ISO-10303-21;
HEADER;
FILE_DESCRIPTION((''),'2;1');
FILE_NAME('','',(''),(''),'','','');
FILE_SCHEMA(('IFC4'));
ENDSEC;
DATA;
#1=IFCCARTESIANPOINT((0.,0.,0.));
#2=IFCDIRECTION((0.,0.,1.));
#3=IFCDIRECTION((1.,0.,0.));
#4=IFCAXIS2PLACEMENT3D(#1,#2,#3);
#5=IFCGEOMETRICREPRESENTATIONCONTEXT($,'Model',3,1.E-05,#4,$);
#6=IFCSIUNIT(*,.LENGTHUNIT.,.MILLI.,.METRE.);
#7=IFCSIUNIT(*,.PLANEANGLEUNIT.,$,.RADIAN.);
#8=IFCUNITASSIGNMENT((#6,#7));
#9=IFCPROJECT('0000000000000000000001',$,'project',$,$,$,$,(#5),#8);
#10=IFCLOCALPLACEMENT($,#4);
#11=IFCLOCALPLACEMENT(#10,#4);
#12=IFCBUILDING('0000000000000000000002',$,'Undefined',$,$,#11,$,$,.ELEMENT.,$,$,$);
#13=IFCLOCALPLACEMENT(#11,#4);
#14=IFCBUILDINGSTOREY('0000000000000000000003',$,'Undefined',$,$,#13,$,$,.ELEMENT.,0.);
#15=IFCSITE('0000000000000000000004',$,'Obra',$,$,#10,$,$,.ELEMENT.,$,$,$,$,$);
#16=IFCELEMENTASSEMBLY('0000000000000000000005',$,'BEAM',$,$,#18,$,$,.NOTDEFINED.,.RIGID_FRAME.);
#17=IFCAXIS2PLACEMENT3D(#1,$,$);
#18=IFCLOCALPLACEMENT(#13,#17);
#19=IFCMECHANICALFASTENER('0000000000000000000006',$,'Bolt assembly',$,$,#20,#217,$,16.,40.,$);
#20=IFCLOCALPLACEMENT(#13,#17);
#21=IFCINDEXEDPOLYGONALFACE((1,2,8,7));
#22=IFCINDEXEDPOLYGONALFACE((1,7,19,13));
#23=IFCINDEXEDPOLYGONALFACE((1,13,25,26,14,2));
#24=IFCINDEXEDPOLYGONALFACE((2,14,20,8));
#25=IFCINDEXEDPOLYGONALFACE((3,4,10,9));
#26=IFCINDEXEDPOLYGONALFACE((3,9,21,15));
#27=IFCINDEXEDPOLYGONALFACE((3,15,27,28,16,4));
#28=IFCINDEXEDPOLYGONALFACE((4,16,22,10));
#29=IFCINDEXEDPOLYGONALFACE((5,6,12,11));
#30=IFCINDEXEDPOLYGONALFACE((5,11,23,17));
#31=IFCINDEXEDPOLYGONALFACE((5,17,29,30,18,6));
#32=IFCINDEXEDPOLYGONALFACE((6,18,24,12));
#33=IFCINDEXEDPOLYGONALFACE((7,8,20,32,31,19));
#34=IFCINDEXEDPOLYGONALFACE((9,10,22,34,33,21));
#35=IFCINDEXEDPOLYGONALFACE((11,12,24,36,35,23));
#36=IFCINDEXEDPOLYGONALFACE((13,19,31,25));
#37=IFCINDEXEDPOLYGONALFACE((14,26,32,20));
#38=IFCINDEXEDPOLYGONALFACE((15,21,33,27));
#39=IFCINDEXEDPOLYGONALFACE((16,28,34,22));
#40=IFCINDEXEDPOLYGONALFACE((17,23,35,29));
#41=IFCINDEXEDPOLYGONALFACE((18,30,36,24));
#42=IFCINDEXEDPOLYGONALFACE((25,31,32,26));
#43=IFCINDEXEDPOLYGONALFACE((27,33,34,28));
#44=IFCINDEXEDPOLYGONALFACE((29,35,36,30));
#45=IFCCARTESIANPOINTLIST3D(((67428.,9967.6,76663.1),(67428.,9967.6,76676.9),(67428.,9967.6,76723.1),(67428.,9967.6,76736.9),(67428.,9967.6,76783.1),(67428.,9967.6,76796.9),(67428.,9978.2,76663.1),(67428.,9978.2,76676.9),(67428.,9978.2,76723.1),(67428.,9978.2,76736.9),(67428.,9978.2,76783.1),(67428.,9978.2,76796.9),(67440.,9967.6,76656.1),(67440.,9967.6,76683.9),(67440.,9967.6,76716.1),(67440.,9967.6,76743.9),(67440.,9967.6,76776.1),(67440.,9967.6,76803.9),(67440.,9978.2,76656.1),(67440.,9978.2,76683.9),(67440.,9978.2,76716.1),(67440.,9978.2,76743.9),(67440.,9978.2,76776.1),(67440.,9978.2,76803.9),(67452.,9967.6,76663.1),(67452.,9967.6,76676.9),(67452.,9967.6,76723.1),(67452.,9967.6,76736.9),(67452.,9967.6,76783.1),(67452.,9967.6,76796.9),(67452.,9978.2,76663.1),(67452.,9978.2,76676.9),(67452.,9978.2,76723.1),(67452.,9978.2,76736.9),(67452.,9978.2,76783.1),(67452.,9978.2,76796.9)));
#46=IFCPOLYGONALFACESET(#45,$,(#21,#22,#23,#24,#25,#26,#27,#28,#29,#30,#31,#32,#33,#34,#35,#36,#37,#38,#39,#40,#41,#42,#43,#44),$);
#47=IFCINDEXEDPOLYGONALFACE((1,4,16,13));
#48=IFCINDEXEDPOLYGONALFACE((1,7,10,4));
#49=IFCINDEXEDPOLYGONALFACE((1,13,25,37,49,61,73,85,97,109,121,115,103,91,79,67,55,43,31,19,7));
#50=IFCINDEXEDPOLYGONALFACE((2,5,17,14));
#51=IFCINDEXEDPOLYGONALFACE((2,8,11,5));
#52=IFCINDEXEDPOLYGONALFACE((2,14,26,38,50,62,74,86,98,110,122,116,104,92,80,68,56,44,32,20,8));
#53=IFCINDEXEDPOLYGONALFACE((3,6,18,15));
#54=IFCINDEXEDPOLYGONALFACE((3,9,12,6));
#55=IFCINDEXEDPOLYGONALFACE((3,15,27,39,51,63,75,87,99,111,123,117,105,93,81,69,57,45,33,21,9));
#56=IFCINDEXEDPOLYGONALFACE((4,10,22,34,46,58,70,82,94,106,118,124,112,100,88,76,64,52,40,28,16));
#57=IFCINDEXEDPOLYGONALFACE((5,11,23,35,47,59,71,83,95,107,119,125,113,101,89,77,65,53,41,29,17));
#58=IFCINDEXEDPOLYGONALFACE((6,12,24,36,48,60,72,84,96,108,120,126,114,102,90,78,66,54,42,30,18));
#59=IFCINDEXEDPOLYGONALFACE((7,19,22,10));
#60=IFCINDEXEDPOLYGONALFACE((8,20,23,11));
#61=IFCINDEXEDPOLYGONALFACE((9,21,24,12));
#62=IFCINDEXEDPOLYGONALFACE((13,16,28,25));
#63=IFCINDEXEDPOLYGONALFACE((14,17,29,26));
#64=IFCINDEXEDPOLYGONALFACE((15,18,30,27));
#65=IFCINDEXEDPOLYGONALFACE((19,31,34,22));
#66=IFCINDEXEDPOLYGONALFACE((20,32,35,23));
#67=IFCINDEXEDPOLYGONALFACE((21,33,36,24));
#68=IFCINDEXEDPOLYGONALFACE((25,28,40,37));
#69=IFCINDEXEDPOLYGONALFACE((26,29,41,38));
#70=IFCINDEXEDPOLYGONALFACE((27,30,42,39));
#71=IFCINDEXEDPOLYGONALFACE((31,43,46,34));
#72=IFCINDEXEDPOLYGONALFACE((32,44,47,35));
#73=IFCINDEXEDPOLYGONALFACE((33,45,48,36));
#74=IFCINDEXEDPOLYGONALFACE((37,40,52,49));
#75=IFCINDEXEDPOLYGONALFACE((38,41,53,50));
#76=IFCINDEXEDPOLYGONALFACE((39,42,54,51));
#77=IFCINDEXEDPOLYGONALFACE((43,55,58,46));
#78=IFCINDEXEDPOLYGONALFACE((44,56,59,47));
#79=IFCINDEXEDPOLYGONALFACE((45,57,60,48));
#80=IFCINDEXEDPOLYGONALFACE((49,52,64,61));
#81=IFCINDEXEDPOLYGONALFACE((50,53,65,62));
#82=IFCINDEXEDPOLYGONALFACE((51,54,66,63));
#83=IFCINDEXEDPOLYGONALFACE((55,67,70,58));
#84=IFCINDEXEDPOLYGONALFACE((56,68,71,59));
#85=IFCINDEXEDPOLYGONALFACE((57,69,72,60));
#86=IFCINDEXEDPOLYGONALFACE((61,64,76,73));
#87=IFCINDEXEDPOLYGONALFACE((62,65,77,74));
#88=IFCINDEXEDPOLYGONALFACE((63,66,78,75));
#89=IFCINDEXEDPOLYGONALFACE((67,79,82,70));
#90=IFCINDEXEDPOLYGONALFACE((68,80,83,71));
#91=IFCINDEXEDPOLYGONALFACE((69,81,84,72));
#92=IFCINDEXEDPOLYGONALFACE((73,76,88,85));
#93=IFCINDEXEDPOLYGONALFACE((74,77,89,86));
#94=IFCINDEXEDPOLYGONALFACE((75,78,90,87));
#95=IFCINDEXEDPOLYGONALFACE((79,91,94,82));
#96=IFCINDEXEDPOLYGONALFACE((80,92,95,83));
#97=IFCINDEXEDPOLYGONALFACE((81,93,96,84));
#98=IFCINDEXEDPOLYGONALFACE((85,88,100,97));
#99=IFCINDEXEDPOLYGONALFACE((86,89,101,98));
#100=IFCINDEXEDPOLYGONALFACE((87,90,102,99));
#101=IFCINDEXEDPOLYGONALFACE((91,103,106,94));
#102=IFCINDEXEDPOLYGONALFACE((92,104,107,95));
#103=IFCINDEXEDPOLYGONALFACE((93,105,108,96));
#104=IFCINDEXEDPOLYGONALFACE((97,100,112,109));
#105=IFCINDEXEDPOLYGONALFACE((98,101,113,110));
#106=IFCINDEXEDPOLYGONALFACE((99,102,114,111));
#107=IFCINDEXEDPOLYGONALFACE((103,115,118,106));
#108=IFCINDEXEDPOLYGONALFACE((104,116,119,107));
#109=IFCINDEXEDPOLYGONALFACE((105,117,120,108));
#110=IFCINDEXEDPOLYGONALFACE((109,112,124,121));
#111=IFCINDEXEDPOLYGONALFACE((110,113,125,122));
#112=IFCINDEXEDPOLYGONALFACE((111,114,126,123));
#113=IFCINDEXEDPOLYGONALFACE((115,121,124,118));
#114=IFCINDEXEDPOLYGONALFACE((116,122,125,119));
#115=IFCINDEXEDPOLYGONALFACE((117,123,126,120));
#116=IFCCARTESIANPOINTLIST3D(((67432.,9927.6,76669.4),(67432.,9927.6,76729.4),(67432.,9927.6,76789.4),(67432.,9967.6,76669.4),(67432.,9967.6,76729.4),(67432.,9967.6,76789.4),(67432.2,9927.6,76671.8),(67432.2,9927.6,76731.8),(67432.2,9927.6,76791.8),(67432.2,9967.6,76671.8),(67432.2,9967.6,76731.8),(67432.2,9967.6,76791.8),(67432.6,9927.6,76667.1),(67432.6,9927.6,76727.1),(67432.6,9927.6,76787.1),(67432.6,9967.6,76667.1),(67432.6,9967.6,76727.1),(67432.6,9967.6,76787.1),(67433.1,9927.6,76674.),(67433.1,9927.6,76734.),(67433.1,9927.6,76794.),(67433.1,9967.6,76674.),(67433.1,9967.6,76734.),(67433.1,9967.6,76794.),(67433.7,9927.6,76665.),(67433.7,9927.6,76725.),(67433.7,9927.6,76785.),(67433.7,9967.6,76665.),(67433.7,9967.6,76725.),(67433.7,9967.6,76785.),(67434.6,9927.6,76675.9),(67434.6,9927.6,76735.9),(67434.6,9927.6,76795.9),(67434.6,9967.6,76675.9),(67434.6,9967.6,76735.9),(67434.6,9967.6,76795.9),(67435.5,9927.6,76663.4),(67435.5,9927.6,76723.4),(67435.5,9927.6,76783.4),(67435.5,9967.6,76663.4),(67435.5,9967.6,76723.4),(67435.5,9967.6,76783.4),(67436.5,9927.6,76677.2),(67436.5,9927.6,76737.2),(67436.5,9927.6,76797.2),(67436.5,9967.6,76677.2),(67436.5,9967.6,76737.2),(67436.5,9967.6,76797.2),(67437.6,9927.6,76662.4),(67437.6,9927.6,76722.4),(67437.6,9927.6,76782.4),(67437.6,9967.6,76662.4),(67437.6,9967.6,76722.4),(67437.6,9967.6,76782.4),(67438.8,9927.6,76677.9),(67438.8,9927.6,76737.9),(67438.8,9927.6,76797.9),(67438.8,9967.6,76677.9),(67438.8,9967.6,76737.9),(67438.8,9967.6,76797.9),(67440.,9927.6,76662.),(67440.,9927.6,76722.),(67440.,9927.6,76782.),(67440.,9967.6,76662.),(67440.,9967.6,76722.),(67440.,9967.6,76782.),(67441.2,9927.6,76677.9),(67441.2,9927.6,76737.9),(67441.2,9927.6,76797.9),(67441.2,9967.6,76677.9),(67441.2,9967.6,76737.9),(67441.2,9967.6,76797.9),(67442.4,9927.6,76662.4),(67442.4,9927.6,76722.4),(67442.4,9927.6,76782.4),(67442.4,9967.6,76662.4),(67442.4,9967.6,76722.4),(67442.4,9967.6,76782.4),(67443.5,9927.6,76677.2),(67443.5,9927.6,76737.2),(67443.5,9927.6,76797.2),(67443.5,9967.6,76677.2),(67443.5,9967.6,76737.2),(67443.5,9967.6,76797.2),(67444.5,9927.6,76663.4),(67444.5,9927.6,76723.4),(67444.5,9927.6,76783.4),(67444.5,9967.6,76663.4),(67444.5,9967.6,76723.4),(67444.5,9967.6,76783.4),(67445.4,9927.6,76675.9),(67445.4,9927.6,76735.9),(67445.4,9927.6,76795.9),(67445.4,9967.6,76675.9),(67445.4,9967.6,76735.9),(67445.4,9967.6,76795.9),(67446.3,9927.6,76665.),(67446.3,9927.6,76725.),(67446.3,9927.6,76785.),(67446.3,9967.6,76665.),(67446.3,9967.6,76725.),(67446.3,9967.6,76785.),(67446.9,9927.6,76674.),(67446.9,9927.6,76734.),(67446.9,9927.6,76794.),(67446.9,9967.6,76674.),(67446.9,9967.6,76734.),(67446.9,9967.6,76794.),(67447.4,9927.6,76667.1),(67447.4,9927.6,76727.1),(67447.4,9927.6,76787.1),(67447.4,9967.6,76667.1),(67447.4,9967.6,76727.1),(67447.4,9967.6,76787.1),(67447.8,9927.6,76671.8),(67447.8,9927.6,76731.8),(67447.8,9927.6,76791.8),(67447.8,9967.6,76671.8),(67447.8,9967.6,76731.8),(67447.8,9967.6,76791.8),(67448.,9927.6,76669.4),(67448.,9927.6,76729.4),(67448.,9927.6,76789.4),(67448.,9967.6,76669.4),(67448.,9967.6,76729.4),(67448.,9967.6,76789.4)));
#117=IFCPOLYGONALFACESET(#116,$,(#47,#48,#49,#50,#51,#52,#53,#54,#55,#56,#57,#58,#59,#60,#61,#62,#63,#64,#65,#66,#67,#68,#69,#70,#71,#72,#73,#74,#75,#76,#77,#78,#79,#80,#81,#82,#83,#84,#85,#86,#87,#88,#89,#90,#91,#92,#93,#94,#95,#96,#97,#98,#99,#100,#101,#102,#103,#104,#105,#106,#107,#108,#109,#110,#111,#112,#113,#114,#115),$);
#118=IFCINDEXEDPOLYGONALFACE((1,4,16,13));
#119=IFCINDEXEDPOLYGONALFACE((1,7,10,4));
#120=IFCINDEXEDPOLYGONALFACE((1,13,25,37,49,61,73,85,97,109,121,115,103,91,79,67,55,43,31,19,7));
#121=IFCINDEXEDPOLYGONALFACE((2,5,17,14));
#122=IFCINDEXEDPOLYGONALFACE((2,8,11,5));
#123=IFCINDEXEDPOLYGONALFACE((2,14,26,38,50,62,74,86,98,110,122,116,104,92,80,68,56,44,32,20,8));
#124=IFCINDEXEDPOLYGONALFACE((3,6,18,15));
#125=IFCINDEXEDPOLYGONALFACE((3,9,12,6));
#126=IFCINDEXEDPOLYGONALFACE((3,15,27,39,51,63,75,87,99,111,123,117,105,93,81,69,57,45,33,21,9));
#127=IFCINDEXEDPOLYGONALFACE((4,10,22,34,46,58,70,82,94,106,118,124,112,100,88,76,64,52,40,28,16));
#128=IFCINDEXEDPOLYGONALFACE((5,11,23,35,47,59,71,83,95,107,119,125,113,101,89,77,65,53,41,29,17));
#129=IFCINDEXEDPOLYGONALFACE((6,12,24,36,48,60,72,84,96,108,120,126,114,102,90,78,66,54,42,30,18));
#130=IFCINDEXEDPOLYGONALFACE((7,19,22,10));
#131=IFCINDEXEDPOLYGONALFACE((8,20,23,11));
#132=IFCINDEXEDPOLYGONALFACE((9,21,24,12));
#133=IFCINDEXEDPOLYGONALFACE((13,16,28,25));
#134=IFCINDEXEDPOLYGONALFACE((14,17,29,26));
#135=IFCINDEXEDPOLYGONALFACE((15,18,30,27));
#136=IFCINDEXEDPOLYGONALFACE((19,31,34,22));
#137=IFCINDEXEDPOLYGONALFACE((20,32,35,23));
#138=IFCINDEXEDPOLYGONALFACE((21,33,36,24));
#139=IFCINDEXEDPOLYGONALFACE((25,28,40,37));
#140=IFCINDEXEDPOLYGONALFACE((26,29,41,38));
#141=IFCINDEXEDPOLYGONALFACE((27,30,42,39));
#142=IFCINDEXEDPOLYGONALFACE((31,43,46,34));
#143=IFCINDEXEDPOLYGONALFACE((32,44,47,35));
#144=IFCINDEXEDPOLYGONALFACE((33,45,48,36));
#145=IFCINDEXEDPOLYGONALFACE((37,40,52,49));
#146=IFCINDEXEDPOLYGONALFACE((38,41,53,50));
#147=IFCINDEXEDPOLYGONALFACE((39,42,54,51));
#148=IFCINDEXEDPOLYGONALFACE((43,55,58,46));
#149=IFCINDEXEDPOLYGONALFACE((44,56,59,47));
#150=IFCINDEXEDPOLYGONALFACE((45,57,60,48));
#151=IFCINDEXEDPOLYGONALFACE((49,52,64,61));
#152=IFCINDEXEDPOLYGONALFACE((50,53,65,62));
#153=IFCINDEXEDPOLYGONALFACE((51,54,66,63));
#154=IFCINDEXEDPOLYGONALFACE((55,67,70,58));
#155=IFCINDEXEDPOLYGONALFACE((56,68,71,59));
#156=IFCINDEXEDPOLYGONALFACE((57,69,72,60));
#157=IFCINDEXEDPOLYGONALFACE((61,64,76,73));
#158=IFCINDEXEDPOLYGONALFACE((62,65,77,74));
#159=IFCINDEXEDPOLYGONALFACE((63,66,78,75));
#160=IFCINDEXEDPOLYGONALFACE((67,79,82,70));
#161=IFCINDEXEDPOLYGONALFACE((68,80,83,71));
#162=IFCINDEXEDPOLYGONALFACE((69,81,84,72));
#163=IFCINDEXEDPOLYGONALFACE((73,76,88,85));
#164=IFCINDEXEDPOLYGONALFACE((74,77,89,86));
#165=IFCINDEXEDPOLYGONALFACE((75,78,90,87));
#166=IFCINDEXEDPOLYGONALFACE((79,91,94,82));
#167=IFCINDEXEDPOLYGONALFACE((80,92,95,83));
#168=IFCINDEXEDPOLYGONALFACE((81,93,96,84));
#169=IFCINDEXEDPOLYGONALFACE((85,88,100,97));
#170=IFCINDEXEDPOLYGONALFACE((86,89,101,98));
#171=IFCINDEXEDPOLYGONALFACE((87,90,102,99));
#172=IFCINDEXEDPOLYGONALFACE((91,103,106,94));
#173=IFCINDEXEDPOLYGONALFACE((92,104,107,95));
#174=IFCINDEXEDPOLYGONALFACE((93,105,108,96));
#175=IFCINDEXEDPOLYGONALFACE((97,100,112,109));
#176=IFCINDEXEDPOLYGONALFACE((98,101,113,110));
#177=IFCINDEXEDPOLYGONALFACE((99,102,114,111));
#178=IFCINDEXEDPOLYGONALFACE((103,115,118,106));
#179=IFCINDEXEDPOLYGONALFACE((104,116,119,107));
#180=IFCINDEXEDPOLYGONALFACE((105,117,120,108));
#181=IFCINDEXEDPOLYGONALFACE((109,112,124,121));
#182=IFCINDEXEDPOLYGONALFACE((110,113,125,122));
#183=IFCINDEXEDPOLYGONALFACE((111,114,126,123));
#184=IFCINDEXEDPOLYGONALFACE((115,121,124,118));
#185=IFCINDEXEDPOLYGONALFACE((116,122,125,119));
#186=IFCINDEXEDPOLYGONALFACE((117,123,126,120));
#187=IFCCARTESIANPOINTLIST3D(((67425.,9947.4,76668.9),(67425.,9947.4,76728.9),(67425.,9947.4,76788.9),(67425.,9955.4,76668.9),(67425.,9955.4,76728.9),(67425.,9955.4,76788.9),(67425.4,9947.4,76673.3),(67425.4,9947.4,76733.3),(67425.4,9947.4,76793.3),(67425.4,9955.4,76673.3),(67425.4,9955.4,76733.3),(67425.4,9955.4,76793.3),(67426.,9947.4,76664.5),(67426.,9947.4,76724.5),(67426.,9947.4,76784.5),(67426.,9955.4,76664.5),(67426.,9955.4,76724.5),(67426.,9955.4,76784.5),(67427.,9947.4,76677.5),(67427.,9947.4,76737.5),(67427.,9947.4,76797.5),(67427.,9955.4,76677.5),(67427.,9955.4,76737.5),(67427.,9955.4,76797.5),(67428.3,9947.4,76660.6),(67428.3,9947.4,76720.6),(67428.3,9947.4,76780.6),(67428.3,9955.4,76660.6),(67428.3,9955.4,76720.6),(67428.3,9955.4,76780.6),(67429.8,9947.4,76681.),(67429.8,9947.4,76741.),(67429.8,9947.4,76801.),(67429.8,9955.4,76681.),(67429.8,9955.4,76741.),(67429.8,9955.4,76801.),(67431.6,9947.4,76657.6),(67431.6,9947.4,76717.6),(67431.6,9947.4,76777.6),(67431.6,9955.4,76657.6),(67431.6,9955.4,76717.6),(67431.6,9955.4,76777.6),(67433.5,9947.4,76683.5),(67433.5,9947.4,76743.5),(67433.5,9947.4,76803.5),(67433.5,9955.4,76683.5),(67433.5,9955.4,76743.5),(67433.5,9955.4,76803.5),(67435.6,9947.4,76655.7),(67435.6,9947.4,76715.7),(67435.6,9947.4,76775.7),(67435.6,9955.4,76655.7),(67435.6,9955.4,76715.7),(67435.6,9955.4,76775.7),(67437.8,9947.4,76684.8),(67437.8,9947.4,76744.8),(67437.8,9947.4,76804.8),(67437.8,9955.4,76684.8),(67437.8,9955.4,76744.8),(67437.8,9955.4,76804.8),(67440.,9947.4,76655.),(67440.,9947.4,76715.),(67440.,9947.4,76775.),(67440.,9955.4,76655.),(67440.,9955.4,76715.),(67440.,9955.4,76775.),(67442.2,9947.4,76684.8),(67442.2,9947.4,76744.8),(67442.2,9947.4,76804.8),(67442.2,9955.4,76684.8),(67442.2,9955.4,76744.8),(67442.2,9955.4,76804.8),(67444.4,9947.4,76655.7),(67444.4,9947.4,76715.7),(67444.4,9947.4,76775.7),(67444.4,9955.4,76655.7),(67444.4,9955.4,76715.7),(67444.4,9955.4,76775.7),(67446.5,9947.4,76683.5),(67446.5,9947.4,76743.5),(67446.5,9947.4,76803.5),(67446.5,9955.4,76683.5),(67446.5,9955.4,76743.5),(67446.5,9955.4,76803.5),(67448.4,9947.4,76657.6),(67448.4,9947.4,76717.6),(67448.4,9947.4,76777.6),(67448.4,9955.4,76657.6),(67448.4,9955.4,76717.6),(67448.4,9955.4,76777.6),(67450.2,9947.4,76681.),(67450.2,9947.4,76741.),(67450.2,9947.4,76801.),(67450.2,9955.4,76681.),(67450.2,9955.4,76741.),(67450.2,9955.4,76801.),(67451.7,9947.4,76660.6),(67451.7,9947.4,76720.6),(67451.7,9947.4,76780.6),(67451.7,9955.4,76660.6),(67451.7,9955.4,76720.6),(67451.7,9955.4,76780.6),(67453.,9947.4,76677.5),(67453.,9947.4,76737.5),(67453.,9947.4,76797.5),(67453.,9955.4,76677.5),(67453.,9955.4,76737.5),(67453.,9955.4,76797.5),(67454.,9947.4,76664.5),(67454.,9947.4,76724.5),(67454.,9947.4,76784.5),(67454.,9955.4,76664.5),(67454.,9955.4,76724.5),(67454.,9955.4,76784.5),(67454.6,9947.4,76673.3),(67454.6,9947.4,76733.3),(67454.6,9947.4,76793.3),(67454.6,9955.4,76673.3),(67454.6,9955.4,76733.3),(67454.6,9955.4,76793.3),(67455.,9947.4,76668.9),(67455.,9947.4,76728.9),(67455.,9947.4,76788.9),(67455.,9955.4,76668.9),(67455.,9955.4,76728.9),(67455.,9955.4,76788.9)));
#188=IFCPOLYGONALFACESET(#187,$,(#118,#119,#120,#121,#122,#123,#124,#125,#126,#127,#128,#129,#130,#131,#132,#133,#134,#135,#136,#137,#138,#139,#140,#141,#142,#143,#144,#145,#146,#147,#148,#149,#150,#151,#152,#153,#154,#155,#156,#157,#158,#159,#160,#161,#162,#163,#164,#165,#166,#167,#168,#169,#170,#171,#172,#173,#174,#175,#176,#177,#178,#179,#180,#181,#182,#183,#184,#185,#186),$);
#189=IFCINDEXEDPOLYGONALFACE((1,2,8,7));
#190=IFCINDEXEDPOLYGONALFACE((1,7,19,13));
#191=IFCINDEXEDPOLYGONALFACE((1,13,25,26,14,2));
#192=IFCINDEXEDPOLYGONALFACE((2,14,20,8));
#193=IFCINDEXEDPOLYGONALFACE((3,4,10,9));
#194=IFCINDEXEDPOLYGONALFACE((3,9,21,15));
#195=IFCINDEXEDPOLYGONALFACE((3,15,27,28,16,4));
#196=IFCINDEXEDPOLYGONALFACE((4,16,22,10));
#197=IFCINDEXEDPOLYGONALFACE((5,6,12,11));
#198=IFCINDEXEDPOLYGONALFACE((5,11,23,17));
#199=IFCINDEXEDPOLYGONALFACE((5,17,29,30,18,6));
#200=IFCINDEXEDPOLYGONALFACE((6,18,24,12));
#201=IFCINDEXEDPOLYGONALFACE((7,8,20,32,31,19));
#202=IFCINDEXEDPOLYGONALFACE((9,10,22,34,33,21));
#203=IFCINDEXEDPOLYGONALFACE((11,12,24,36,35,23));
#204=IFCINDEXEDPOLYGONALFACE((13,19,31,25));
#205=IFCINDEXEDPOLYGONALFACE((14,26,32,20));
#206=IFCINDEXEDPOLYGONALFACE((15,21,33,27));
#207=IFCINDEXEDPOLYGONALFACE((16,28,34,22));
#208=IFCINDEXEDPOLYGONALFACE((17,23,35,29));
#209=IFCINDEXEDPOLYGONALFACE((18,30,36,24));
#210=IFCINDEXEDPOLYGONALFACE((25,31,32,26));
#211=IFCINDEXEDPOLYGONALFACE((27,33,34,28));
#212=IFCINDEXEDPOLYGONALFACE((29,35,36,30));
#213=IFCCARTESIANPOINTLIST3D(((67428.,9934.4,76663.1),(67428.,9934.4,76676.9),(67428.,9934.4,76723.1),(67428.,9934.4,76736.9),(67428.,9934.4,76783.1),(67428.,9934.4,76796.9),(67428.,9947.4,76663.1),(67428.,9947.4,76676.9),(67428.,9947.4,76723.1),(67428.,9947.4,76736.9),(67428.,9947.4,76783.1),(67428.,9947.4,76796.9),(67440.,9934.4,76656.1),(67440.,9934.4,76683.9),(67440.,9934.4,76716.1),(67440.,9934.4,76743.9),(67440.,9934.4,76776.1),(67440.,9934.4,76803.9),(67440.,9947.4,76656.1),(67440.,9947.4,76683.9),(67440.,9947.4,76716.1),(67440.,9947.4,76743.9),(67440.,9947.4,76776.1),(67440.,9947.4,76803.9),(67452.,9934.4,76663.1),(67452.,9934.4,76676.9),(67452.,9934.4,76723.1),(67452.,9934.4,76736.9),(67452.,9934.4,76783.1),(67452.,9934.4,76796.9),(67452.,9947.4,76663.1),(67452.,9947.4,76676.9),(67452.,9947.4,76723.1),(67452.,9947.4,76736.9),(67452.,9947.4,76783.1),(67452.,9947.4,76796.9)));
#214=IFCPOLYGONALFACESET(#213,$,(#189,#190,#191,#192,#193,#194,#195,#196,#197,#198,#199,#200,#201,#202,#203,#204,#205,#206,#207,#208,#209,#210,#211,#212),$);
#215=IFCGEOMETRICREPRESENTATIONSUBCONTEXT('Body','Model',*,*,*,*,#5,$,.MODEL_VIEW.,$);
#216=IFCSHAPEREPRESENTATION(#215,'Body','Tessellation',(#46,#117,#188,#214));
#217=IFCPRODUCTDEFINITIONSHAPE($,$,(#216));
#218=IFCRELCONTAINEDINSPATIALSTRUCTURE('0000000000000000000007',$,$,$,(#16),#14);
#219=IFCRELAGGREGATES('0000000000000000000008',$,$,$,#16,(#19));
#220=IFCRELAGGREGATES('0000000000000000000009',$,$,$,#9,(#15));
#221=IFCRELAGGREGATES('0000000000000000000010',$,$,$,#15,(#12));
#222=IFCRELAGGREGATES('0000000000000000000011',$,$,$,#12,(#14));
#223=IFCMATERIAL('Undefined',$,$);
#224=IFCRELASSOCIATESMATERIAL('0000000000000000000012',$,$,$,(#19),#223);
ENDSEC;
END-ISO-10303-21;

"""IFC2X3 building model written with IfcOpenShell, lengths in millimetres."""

from ifc_helpers import new_model, si_unit, frame, origin_with_axes, origin_2d_with_axis, place, context, subcontext, project, spatial, polyline, circle, outline, extrude, source, transform, mapped, material, element, aggregate, save


model = new_model("IFC2X3")

# Units and contexts
model_context = context("Model", 3, precision=1e-05, world=origin_with_axes())
body_context = subcontext(model_context, "Body", "Model", "MODEL_VIEW")
ifc_project = project(units=[si_unit("LENGTHUNIT", "METRE", prefix="MILLI"), si_unit("PLANEANGLEUNIT", "RADIAN")], contexts=[model_context])

# Site, building, storey
site_placement = place(None, origin_with_axes())
site = spatial("IfcSite", under=ifc_project, at=site_placement, Name="Obra", CompositionType="ELEMENT")
building_placement = place(site_placement, origin_with_axes())
building = spatial("IfcBuilding", under=site, at=building_placement, Name="Undefined", CompositionType="ELEMENT")
storey_placement = place(building_placement, origin_with_axes())
storey = spatial("IfcBuildingStorey", under=building, at=storey_placement, Name="Undefined", CompositionType="ELEMENT", Elevation=0.0)

# Element assembly
assembly_1_placement = place(storey_placement, origin_with_axes())
assembly_1 = element("IfcElementAssembly", 1, at=assembly_1_placement, inside=storey, Name="BEAM", AssemblyPlace="NOTDEFINED", PredefinedType="RIGID_FRAME")

# Shared definitions
ifc_material_1 = material(Name="Undefined")

# Mechanical fastener
shared_shape_1 = source(origin_with_axes(), body_context, "Body", "SweptSolid", [
    extrude(outline(polyline([(13.9, 0.0), (6.9, 12.0), (-6.9, 12.0), (-13.9, 0.0), (-6.9, -12.0), (6.9, -12.0), (13.9, 0.0)])), frame((0.0, -19.7, 0.0), z_axis=(0.0, 1.0, 0.0), x_axis=(1.0, 0.0, 0.0)), (0.0, 0.0, 1.0), 10.6),
    extrude(circle(Radius=8.0, at=origin_2d_with_axis()), frame((0.0, -9.1, 0.0), z_axis=(0.0, 1.0, 0.0), x_axis=(1.0, 0.0, 0.0)), (0.0, 0.0, 1.0), 40.0),
    extrude(circle(Radius=15.0, at=origin_2d_with_axis()), frame((0.0, 3.1, 0.0), z_axis=(0.0, 1.0, 0.0), x_axis=(1.0, 0.0, 0.0)), (0.0, 0.0, 1.0), 8.0),
    extrude(outline(polyline([(13.9, 0.0), (6.9, 12.0), (-6.9, 12.0), (-13.9, 0.0), (-6.9, -12.0), (6.9, -12.0), (13.9, 0.0)])), frame((0.0, 11.1, 0.0), z_axis=(0.0, 1.0, 0.0), x_axis=(1.0, 0.0, 0.0)), (0.0, 0.0, 1.0), 13.0),
])
mechanical_fastener_1_placement = place(assembly_1_placement, frame((67490.0, 9958.5, 76850.0), z_axis=(-1.0, 0.0, 0.0), x_axis=(0.0, 0.0, -1.0)))
mechanical_fastener_1 = element("IfcMechanicalFastener", 2, at=mechanical_fastener_1_placement, material=ifc_material_1, Name="Bolt assembly", NominalDiameter=16.0, NominalLength=40.0, context=body_context, shape_type="MappedRepresentation", body=[
    mapped(shared_shape_1, transform((60.0, 0.0, 50.0))),
    mapped(shared_shape_1, transform((120.0, 0.0, 50.0))),
    mapped(shared_shape_1, transform((180.0, 0.0, 50.0))),
])
aggregate(assembly_1, [mechanical_fastener_1])

save(model, "model.ifc")
